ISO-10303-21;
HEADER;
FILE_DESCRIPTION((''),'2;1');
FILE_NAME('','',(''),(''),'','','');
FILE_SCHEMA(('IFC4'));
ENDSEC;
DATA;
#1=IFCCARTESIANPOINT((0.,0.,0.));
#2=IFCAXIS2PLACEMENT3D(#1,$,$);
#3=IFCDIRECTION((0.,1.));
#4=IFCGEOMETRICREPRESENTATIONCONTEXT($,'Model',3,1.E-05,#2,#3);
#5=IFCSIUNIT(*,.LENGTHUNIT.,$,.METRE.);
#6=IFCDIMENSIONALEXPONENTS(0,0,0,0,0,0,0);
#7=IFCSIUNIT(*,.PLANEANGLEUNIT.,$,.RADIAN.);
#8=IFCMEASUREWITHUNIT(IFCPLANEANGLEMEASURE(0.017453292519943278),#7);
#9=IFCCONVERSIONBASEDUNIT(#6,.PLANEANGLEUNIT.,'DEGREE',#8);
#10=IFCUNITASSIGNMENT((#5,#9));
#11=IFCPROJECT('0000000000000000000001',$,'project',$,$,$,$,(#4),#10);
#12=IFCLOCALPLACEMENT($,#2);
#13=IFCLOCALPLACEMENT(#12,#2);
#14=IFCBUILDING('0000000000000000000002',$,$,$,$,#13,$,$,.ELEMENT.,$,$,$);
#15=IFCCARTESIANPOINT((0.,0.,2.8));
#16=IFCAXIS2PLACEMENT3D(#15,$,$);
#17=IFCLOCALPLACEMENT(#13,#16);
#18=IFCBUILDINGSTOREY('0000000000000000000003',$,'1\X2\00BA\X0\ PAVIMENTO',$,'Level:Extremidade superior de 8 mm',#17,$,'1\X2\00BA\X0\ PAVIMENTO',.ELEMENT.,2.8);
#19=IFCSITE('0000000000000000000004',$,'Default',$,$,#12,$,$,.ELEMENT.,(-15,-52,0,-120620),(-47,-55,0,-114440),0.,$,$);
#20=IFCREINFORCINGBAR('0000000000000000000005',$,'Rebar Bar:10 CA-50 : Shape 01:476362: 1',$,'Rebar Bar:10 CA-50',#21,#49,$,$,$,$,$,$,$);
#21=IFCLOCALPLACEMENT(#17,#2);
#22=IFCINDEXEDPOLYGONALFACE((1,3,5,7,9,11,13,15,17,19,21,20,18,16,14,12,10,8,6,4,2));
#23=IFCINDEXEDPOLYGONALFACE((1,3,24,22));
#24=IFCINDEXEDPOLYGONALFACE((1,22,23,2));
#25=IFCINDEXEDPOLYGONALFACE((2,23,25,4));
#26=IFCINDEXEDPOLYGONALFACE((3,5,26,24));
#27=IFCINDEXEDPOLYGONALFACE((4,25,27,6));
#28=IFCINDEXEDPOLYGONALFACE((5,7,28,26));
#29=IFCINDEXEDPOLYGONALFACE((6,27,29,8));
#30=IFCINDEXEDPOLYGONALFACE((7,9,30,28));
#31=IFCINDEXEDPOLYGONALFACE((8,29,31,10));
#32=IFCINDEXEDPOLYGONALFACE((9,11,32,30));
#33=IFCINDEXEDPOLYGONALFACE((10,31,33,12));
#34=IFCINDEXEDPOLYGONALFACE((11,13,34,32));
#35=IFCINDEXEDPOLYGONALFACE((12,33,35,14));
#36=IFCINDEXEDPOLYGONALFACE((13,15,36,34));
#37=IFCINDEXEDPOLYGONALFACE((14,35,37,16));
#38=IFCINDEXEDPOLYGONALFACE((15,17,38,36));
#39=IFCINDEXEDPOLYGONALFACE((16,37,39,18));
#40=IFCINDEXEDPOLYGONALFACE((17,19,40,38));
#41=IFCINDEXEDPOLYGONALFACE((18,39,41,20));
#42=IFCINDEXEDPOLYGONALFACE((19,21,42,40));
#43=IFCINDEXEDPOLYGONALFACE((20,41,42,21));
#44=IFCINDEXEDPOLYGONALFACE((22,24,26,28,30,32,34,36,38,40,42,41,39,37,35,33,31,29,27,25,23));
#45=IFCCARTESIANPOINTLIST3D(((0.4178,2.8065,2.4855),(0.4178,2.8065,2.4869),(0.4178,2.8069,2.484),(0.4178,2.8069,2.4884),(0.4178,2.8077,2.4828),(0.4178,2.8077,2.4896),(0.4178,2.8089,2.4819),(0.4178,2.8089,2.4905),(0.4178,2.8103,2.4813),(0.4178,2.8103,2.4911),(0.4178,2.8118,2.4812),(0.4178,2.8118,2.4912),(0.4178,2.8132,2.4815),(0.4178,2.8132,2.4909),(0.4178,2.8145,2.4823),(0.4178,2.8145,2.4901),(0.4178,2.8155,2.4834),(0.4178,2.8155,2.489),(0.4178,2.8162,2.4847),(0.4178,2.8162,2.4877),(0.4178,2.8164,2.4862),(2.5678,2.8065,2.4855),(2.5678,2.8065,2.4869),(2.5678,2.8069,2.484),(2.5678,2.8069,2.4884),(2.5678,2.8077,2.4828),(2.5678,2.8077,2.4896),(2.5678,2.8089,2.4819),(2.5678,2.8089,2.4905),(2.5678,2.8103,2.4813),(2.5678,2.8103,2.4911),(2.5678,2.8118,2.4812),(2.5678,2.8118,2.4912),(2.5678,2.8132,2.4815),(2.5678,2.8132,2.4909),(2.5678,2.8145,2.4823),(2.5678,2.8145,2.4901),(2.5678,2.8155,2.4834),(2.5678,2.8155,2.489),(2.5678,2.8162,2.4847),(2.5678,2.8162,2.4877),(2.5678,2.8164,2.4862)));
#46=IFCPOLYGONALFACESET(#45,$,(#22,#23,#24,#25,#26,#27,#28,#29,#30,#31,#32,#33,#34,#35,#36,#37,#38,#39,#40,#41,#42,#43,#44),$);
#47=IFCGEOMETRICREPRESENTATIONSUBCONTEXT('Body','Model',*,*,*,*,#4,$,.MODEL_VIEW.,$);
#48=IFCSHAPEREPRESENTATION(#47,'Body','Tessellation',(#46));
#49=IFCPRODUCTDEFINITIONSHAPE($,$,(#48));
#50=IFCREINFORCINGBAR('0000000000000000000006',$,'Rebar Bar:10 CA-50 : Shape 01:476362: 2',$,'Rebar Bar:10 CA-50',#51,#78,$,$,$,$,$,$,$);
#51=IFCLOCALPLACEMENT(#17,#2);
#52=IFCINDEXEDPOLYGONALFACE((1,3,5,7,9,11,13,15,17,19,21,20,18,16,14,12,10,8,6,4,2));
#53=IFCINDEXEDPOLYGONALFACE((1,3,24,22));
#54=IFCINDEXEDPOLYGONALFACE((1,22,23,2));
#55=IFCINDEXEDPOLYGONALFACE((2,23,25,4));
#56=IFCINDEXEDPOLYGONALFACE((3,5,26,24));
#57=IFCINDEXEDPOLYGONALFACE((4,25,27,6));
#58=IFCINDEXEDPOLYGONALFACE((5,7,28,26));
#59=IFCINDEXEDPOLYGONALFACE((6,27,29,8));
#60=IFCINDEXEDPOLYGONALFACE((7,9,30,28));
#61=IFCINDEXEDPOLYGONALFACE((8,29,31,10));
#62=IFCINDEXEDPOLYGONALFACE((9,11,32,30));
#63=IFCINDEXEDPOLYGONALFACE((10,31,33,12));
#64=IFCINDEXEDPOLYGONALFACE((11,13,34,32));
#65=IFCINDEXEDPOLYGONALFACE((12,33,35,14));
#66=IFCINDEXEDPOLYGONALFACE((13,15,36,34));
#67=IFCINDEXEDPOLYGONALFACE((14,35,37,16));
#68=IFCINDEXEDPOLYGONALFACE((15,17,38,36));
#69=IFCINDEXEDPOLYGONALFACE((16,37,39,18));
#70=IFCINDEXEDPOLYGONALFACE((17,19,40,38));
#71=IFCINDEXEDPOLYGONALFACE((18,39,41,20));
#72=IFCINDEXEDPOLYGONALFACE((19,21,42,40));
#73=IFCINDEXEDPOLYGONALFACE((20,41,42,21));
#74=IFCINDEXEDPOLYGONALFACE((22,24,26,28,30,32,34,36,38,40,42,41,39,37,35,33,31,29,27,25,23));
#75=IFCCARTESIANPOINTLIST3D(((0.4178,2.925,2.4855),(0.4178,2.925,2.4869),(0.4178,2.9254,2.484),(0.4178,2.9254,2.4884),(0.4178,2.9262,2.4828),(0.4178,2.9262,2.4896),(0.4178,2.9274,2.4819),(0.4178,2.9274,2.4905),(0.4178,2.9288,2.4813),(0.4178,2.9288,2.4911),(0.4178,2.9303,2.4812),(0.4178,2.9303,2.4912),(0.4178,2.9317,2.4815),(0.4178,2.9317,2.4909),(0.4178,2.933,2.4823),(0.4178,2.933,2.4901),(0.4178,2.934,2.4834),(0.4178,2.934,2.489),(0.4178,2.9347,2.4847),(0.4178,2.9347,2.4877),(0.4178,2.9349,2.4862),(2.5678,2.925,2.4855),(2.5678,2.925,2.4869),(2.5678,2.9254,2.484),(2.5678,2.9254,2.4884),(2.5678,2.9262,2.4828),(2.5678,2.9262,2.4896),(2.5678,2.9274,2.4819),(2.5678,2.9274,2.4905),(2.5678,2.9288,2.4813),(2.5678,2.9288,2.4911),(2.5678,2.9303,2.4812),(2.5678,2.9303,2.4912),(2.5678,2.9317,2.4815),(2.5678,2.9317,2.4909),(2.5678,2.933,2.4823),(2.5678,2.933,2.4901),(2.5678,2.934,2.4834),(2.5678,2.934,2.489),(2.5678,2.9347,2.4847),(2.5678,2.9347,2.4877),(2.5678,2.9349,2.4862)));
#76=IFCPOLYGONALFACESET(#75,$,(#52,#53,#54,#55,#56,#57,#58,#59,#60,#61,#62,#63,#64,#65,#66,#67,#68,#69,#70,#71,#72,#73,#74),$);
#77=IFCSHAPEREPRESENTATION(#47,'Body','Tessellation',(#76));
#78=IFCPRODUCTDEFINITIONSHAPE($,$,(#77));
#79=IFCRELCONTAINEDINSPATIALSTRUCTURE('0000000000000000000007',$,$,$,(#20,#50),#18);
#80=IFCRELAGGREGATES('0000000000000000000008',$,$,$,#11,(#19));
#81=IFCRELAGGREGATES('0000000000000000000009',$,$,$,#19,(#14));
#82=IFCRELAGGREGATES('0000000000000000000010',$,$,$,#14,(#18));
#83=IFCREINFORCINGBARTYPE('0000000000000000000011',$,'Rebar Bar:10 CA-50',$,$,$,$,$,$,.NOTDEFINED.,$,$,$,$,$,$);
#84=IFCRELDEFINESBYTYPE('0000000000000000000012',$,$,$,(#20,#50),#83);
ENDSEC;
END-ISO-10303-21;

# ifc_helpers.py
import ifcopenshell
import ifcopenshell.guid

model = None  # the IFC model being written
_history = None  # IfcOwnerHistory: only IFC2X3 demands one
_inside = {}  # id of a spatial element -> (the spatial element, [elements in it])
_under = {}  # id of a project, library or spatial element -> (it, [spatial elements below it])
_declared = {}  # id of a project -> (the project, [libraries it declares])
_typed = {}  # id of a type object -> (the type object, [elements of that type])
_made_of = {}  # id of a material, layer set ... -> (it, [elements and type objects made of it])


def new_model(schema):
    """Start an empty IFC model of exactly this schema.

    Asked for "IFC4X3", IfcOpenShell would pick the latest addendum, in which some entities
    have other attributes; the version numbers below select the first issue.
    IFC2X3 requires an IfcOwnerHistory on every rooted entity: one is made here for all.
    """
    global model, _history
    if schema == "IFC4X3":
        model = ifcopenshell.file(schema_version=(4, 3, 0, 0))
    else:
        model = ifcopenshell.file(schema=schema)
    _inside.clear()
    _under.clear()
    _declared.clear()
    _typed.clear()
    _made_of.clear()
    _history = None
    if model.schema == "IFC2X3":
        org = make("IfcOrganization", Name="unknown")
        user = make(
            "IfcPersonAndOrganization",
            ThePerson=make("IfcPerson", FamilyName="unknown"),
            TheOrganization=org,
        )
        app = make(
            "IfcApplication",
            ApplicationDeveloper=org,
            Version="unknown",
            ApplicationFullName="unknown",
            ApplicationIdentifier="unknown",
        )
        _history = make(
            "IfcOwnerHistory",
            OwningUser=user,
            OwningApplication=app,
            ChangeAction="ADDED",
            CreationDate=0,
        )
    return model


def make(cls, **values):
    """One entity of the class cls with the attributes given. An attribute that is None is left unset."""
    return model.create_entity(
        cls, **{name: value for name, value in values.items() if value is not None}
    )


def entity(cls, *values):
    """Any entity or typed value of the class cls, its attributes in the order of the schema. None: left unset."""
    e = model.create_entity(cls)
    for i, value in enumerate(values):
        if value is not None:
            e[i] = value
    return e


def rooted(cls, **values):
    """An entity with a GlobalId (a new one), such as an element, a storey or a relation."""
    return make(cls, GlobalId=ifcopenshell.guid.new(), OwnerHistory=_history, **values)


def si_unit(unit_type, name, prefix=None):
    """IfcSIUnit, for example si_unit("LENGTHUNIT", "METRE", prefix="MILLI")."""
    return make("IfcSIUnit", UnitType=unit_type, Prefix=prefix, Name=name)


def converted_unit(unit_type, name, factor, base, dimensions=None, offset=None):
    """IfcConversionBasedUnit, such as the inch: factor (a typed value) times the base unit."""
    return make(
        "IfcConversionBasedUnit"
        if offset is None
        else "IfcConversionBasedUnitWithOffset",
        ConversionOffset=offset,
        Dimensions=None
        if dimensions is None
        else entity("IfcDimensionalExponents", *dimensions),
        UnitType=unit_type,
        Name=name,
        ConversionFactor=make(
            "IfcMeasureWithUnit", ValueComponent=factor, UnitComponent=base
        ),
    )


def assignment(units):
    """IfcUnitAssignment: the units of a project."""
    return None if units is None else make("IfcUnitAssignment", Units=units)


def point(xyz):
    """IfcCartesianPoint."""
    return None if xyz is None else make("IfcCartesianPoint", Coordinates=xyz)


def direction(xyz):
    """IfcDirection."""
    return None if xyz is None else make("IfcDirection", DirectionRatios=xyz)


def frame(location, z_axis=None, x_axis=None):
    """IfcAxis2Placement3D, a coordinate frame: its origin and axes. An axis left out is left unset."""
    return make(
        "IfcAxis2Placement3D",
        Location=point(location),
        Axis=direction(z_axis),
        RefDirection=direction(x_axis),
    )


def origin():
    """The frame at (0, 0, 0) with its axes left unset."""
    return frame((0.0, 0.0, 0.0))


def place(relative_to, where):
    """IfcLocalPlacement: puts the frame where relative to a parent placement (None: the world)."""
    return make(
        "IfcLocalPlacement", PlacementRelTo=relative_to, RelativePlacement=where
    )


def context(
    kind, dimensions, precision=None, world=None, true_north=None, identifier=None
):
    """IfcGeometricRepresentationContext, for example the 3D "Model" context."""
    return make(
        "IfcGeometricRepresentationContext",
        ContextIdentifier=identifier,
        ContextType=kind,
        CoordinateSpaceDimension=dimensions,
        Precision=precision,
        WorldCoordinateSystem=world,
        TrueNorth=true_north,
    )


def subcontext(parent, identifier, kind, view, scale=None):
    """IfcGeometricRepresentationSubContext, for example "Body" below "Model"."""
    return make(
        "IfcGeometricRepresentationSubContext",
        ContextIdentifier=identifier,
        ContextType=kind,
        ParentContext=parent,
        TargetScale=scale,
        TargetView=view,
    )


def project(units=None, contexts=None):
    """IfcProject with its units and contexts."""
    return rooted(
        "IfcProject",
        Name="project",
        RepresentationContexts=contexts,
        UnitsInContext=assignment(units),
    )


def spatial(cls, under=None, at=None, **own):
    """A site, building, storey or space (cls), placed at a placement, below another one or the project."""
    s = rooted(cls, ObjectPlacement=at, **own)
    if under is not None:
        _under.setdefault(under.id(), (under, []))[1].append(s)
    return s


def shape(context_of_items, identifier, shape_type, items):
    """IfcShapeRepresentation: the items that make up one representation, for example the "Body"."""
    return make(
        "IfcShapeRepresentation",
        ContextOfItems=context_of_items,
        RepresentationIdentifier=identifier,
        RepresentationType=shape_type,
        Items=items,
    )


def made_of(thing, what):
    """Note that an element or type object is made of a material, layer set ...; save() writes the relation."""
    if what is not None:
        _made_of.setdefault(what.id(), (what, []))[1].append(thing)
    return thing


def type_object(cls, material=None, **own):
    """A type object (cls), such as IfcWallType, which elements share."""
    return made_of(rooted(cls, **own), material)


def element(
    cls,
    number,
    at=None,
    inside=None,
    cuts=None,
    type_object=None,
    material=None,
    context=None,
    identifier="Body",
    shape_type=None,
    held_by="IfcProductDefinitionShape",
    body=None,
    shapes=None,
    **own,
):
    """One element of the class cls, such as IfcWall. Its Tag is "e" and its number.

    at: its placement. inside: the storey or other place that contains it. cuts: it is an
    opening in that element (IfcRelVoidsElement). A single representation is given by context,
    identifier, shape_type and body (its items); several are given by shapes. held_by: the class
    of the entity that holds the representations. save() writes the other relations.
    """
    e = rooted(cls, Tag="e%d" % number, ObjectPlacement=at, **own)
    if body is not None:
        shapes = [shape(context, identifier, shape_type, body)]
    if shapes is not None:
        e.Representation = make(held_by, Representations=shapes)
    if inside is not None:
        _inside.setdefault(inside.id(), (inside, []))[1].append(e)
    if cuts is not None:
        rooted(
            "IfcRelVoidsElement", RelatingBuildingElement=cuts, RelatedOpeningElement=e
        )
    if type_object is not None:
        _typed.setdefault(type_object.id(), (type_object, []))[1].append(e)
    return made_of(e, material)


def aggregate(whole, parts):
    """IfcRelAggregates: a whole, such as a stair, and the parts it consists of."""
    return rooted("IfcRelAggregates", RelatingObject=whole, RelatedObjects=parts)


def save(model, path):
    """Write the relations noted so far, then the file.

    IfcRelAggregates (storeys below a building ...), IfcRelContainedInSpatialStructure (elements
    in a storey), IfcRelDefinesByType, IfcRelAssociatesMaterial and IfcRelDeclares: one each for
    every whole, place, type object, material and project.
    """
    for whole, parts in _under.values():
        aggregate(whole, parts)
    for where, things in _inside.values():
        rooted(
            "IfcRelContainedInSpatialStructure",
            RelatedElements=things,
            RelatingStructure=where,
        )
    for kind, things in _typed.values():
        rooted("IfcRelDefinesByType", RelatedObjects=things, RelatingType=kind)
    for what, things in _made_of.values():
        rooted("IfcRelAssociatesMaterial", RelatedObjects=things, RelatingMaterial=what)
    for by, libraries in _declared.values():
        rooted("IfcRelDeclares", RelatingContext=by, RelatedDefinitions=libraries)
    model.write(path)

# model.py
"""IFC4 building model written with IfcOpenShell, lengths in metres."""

from ifc_helpers import new_model, entity, si_unit, converted_unit, direction, frame, origin, place, context, subcontext, project, spatial, type_object, element, save


model = new_model("IFC4")

# Units and contexts
model_context = context("Model", 3, precision=1e-05, world=origin(), true_north=direction((0.0, 1.0)))
body_context = subcontext(model_context, "Body", "Model", "MODEL_VIEW")
ifc_project = project(units=[si_unit("LENGTHUNIT", "METRE"), converted_unit("PLANEANGLEUNIT", "DEGREE", entity("IfcPlaneAngleMeasure", 0.017453292519943278), si_unit("PLANEANGLEUNIT", "RADIAN"), dimensions=[0, 0, 0, 0, 0, 0, 0])], contexts=[model_context])

# Site, building, storey
site_placement = place(None, origin())
site = spatial("IfcSite", under=ifc_project, at=site_placement, Name="Default", CompositionType="ELEMENT", RefLatitude=(-15, -52, 0, -120620), RefLongitude=(-47, -55, 0, -114440), RefElevation=0.0)
building_placement = place(site_placement, origin())
building = spatial("IfcBuilding", under=site, at=building_placement, CompositionType="ELEMENT")
storey_placement = place(building_placement, frame((0.0, 0.0, 2.8)))
storey = spatial("IfcBuildingStorey", under=building, at=storey_placement, Name="1º PAVIMENTO", ObjectType="Level:Extremidade superior de 8 mm", LongName="1º PAVIMENTO", CompositionType="ELEMENT", Elevation=2.8)

# Reinforcing bars
reinforcing_bar_type_1 = type_object("IfcReinforcingBarType", Name="Rebar Bar:10 CA-50", PredefinedType="NOTDEFINED")
reinforcing_bar_1_placement = place(storey_placement, origin())
element("IfcReinforcingBar", 1, at=reinforcing_bar_1_placement, inside=storey, type_object=reinforcing_bar_type_1, Name="Rebar Bar:10 CA-50 : Shape 01:476362: 1", ObjectType="Rebar Bar:10 CA-50", context=body_context, shape_type="AdvancedSweptSolid", body=[
    entity("IfcSweptDiskSolid", entity("IfcIndexedPolyCurve", entity("IfcCartesianPointList3D", [[0.4178, 2.8114, 2.4862], [2.5678, 2.8114, 2.4862]]), None, False), 0.005, None, 0.0, 1.0),
])
reinforcing_bar_2_placement = place(storey_placement, origin())
element("IfcReinforcingBar", 2, at=reinforcing_bar_2_placement, inside=storey, type_object=reinforcing_bar_type_1, Name="Rebar Bar:10 CA-50 : Shape 01:476362: 2", ObjectType="Rebar Bar:10 CA-50", context=body_context, shape_type="AdvancedSweptSolid", body=[
    entity("IfcSweptDiskSolid", entity("IfcIndexedPolyCurve", entity("IfcCartesianPointList3D", [[0.4178, 2.9299, 2.4862], [2.5678, 2.9299, 2.4862]]), None, False), 0.005, None, 0.0, 1.0),
])

save(model, "model.ifc")
